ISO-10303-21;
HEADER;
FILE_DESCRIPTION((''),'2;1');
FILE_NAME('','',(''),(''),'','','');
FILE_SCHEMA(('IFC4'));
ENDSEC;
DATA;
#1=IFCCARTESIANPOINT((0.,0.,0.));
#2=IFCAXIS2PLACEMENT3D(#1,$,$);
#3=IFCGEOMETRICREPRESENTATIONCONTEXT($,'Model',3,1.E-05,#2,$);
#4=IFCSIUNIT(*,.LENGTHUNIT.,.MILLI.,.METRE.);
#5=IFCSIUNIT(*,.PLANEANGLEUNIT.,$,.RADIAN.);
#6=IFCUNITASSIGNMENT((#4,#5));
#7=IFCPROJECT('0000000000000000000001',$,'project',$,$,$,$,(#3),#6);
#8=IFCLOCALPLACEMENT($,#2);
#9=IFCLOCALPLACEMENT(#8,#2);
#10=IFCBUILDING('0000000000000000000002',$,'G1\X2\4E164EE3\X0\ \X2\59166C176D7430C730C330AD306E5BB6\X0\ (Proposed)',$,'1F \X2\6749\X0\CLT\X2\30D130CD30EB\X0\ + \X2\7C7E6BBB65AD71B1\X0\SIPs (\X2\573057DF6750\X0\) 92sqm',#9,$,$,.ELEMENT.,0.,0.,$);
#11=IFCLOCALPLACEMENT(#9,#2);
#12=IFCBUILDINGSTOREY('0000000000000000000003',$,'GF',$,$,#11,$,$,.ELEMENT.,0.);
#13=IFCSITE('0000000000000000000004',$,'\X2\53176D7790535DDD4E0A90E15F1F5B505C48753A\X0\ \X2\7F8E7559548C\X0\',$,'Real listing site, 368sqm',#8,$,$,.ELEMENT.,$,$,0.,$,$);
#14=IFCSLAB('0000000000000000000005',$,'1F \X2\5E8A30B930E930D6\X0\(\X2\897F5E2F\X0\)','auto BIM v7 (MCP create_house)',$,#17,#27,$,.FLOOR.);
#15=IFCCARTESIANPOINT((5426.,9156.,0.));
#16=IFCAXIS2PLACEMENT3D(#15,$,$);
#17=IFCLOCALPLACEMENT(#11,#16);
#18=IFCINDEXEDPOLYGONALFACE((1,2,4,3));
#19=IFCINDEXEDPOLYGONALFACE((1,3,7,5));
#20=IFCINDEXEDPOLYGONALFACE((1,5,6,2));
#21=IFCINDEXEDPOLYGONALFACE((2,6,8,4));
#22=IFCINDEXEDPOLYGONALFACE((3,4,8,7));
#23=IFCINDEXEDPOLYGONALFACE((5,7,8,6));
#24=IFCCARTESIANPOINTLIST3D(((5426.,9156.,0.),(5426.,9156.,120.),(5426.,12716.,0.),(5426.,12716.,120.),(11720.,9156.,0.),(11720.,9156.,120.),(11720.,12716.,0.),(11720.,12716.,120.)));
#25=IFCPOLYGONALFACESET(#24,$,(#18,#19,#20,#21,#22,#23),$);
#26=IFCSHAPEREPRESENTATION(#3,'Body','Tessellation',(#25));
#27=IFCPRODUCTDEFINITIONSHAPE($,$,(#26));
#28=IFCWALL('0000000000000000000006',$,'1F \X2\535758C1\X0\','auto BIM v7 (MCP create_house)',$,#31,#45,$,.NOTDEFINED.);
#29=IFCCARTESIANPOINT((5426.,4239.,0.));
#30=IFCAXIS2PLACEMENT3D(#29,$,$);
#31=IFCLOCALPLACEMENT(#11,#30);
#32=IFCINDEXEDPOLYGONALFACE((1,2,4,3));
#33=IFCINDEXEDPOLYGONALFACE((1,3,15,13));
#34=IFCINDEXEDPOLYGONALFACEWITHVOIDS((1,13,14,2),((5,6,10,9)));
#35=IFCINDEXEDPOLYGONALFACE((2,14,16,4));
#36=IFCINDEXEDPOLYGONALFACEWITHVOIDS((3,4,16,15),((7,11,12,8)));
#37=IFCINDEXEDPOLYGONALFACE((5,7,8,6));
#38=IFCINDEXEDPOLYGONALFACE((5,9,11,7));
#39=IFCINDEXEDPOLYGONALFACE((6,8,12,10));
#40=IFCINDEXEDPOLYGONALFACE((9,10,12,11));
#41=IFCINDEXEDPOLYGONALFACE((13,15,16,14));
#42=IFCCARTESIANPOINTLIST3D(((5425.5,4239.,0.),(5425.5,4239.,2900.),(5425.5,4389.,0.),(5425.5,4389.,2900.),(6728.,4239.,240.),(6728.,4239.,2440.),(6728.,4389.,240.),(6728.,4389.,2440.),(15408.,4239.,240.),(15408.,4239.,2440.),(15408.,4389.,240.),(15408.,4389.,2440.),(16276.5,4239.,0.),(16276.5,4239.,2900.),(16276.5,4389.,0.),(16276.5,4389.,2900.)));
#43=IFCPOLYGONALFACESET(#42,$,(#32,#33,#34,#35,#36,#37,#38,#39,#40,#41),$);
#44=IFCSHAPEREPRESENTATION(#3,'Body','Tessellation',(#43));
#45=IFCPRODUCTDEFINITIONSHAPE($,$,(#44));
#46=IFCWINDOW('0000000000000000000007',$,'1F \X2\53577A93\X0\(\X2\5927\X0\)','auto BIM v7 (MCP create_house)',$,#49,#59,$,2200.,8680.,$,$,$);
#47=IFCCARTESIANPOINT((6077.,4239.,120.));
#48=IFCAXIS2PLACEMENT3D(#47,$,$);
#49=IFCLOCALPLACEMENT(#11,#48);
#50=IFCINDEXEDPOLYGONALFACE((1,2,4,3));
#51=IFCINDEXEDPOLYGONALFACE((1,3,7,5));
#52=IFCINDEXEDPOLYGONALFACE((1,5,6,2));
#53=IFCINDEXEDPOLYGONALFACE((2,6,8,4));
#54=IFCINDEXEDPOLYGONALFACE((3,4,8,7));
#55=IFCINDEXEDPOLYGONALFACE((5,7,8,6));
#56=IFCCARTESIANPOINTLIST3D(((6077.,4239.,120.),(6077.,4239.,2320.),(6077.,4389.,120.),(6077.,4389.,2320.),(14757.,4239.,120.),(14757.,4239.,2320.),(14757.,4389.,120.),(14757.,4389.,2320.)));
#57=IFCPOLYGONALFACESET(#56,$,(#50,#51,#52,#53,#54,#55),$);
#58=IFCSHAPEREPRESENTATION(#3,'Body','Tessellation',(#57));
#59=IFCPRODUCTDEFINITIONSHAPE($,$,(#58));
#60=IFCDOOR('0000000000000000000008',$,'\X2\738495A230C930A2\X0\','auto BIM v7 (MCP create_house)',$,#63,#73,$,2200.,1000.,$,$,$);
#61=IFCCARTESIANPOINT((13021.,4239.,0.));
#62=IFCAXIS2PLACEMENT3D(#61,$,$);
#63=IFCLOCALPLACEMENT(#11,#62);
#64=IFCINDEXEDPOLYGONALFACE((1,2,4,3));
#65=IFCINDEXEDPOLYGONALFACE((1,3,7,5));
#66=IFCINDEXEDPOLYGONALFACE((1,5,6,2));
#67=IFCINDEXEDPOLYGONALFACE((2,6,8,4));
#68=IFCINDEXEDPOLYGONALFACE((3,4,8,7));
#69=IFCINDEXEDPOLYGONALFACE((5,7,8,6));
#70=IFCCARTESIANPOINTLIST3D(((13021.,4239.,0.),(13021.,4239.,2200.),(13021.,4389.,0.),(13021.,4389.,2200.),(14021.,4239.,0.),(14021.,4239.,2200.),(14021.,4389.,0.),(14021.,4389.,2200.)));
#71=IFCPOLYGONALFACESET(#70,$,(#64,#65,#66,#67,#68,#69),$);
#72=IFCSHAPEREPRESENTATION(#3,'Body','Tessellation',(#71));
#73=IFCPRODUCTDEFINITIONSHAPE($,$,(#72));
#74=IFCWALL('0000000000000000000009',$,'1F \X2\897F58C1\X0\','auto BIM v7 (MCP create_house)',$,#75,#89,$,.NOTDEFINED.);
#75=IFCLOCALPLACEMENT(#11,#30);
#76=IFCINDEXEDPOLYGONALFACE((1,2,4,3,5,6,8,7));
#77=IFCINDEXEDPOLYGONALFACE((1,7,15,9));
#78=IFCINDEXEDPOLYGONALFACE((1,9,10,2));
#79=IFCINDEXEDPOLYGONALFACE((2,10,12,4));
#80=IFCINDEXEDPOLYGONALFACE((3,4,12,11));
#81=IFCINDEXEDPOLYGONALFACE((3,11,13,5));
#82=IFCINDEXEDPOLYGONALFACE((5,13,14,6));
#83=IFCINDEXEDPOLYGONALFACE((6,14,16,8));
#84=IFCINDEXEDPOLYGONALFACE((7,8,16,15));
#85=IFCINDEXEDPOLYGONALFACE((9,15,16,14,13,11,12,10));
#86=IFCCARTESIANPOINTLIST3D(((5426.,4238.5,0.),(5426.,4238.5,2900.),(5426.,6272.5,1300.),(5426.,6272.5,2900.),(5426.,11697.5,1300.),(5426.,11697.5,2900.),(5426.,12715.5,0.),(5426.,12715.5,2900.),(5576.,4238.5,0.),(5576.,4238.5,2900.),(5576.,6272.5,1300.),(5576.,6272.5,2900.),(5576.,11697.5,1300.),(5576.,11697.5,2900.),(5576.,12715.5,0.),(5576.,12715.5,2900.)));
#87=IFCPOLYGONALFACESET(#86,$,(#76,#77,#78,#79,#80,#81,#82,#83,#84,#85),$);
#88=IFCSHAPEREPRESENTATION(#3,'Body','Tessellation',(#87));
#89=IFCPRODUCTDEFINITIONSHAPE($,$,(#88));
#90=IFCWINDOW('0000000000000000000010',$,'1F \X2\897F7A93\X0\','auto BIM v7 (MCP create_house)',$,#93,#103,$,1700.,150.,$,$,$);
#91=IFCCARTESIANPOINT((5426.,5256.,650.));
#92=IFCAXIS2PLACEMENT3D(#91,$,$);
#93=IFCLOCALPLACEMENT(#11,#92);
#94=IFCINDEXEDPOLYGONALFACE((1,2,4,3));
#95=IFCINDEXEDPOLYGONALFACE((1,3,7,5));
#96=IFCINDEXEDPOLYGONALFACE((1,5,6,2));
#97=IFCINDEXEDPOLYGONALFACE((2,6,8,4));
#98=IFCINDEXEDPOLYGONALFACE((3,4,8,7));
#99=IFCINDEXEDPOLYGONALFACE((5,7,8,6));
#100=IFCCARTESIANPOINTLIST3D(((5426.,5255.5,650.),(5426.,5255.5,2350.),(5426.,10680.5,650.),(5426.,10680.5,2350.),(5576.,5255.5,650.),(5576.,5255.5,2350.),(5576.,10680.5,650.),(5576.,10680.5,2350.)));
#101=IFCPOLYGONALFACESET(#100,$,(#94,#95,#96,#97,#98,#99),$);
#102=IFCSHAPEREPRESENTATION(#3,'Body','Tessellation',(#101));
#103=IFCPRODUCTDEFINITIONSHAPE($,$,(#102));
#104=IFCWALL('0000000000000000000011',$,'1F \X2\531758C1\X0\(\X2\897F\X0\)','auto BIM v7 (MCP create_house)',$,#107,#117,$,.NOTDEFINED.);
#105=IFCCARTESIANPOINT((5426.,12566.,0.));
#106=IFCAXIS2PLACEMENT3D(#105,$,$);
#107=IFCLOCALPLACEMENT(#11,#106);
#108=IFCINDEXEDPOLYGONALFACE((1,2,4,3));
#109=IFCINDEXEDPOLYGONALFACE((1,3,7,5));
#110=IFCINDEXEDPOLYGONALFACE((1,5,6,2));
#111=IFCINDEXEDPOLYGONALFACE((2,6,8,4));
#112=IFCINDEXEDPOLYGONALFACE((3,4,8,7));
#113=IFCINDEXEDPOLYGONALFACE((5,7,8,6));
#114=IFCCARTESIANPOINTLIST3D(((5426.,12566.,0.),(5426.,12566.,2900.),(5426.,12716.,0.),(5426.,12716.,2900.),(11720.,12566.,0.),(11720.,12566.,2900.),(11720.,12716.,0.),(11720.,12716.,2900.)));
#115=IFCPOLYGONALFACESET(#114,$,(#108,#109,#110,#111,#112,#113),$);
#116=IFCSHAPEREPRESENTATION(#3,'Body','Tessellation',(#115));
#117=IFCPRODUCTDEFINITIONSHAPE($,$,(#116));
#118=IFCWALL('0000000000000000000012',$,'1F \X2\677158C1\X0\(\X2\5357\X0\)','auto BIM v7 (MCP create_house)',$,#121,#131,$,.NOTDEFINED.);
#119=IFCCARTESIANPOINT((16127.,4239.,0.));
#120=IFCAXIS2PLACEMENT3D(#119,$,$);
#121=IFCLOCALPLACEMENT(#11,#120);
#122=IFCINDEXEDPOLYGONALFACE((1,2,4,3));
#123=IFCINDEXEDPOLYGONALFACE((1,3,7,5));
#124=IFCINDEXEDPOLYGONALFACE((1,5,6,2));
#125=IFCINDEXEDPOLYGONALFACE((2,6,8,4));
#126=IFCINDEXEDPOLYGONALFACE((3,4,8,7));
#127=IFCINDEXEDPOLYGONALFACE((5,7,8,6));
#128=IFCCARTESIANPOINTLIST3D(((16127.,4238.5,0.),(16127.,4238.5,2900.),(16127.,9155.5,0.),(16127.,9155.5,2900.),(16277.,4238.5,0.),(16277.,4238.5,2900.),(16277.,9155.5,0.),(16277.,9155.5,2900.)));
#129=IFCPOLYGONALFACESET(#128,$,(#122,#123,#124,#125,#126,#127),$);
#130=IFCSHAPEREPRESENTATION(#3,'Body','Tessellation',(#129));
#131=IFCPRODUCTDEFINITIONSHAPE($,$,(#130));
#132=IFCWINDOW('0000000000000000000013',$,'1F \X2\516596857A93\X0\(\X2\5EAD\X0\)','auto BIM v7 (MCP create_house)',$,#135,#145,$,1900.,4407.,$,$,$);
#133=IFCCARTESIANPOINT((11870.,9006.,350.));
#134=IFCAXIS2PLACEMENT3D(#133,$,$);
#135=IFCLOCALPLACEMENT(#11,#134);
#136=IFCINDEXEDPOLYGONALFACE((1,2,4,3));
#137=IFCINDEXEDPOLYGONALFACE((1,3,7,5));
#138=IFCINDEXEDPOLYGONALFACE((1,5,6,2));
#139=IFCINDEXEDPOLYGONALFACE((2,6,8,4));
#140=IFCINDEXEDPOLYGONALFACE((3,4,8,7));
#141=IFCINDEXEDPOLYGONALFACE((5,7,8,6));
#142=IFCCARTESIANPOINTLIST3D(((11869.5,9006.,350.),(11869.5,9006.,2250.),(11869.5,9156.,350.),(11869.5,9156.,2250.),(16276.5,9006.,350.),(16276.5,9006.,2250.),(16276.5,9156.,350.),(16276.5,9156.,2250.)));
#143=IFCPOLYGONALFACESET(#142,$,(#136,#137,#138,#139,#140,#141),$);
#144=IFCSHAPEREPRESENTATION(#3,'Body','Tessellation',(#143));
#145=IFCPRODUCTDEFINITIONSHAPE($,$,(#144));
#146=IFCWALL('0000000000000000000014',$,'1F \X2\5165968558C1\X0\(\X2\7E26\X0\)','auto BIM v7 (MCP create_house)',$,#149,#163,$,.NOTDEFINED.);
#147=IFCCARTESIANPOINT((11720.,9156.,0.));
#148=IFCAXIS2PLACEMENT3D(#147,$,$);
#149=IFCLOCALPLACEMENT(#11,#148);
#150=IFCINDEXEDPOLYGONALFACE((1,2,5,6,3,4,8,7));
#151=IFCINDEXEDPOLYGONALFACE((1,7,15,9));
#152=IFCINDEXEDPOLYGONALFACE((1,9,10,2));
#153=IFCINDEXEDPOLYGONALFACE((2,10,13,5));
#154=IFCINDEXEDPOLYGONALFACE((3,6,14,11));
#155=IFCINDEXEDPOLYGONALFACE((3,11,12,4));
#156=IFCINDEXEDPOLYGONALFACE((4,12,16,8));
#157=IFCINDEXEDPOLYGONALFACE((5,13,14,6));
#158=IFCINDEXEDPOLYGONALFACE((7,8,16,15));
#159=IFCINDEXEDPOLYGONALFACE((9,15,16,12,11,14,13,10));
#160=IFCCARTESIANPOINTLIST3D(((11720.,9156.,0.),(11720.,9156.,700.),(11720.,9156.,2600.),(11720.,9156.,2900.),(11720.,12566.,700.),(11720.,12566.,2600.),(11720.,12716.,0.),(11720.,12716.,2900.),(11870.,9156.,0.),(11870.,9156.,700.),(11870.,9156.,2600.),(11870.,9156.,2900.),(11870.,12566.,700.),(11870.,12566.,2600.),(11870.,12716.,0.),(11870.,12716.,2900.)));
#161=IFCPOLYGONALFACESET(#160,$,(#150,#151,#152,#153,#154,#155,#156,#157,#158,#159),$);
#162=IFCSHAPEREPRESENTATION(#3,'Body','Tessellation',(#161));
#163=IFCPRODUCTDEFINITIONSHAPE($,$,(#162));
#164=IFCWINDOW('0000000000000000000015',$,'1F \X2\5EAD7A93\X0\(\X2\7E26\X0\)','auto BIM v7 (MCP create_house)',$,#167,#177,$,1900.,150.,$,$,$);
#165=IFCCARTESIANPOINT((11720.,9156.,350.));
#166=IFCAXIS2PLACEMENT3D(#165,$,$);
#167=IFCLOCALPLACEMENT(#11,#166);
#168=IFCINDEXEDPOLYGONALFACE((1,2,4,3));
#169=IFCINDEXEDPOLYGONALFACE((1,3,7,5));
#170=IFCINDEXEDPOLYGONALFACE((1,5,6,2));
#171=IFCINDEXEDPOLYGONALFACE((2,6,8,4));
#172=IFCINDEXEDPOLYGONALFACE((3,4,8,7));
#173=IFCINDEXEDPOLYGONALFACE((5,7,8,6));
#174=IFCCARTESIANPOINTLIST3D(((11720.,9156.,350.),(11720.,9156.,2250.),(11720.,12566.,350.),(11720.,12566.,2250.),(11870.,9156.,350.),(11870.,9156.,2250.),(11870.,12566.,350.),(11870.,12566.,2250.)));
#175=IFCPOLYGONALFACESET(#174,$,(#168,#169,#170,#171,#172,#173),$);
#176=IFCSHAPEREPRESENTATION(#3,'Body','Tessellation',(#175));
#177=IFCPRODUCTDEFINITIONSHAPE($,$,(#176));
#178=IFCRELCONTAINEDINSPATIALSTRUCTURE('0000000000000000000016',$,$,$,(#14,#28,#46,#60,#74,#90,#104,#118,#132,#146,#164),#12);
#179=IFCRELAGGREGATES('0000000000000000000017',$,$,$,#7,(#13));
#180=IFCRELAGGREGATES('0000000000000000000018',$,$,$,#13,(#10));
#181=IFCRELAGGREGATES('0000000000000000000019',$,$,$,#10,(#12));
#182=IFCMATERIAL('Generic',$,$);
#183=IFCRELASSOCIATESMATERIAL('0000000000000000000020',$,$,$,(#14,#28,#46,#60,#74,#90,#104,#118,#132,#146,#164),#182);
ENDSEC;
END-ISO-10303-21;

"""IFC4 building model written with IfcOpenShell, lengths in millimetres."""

from ifc_helpers import new_model, si_unit, frame, frame_2d, origin, place, context, project, spatial, rectangle, extrude, material, element, fill, save


model = new_model("IFC4")

# Units and contexts
model_context = context("Model", 3, precision=1e-05, world=origin())
ifc_project = project(units=[si_unit("LENGTHUNIT", "METRE", prefix="MILLI"), si_unit("PLANEANGLEUNIT", "RADIAN")], contexts=[model_context])

# Site, building, storey
site_placement = place(None, origin())
site = spatial("IfcSite", under=ifc_project, at=site_placement, Name="北海道川上郡弟子屈町 美留和", ObjectType="Real listing site, 368sqm", CompositionType="ELEMENT", RefElevation=0.0)
building_placement = place(site_placement, origin())
building = spatial("IfcBuilding", under=site, at=building_placement, Name="G1世代 外気浴デッキの家 (Proposed)", ObjectType="1F 杉CLTパネル + 籾殻断熱SIPs (地域材) 92sqm", CompositionType="ELEMENT", ElevationOfRefHeight=0.0, ElevationOfTerrain=0.0)
storey_placement = place(building_placement, origin())
storey = spatial("IfcBuildingStorey", under=building, at=storey_placement, Name="GF", CompositionType="ELEMENT", Elevation=0.0)

# Slab
ifc_material = material(Name="Generic")
slab_1_placement = place(storey_placement, frame((5426.0, 9156.0, 0.0)))
element("IfcSlab", 1, at=slab_1_placement, inside=storey, material=ifc_material, Name="1F 床スラブ(西帯)", Description="auto BIM v7 (MCP create_house)", PredefinedType="FLOOR", context=model_context, shape_type="SweptSolid", body=[
    extrude(rectangle(XDim=6294.0, YDim=3560.0, at=frame_2d((3147.0, 1780.0))), frame((5426.0, 9156.0, 0.0)), (0.0, 0.0, 1.0), 120.0),
])

# Wall, openings, window, door
wall_1_placement = place(storey_placement, frame((5426.0, 4239.0, 0.0)))
wall_1 = element("IfcWall", 2, at=wall_1_placement, inside=storey, material=ifc_material, Name="1F 南壁", Description="auto BIM v7 (MCP create_house)", PredefinedType="NOTDEFINED", context=model_context, shape_type="SweptSolid", body=[
    extrude(rectangle(XDim=10851.0, YDim=150.0, at=frame_2d((5425.0, 75.0))), frame((5426.0, 4239.0, 0.0)), (0.0, 0.0, 1.0), 2900.0),
])
opening_1_placement = place(storey_placement, frame((6077.0, 4239.0, 120.0)))
opening_1 = element("IfcOpeningElement", 3, at=opening_1_placement, cuts=wall_1, PredefinedType="NOTDEFINED", context=model_context, shape_type="SweptSolid", body=[
    extrude(rectangle(XDim=8680.0, YDim=150.0, at=frame_2d((4340.0, 75.0))), frame((6077.0, 4239.0, 120.0)), (0.0, 0.0, 1.0), 2200.0),
])
opening_2_placement = place(storey_placement, frame((13021.0, 4239.0, 0.0)))
opening_2 = element("IfcOpeningElement", 4, at=opening_2_placement, cuts=wall_1, PredefinedType="NOTDEFINED", context=model_context, shape_type="SweptSolid", body=[
    extrude(rectangle(XDim=1000.0, YDim=150.0, at=frame_2d((500.0, 75.0))), frame((13021.0, 4239.0, 0.0)), (0.0, 0.0, 1.0), 2200.0),
])
window_1_placement = place(storey_placement, frame((6077.0, 4239.0, 120.0)))
window_1 = element("IfcWindow", 5, at=window_1_placement, inside=storey, material=ifc_material, Name="1F 南窓(大)", Description="auto BIM v7 (MCP create_house)", OverallHeight=2200.0, OverallWidth=8680.0, context=model_context, shape_type="SweptSolid", body=[
    extrude(rectangle(XDim=8680.0, YDim=150.0, at=frame_2d((4340.0, 75.0))), frame((6077.0, 4239.0, 120.0)), (0.0, 0.0, 1.0), 2200.0),
])
fill(opening_1, window_1)
door_placement = place(storey_placement, frame((13021.0, 4239.0, 0.0)))
door = element("IfcDoor", 6, at=door_placement, inside=storey, material=ifc_material, Name="玄関ドア", Description="auto BIM v7 (MCP create_house)", OverallHeight=2200.0, OverallWidth=1000.0, context=model_context, shape_type="SweptSolid", body=[
    extrude(rectangle(XDim=1000.0, YDim=150.0, at=frame_2d((500.0, 75.0))), frame((13021.0, 4239.0, 0.0)), (0.0, 0.0, 1.0), 2200.0),
])
fill(opening_2, door)

# Wall, opening, window
wall_2_placement = place(storey_placement, frame((5426.0, 4239.0, 0.0)))
wall_2 = element("IfcWall", 7, at=wall_2_placement, inside=storey, material=ifc_material, Name="1F 西壁", Description="auto BIM v7 (MCP create_house)", PredefinedType="NOTDEFINED", context=model_context, shape_type="SweptSolid", body=[
    extrude(rectangle(XDim=150.0, YDim=8477.0, at=frame_2d((75.0, 4238.0))), frame((5426.0, 4239.0, 0.0)), (0.0, 0.0, 1.0), 2900.0),
])
opening_3_placement = place(storey_placement, frame((5426.0, 5256.0, 650.0)))
opening_3 = element("IfcOpeningElement", 8, at=opening_3_placement, cuts=wall_2, PredefinedType="NOTDEFINED", context=model_context, shape_type="SweptSolid", body=[
    extrude(rectangle(XDim=150.0, YDim=5425.0, at=frame_2d((75.0, 2712.0))), frame((5426.0, 5256.0, 650.0)), (0.0, 0.0, 1.0), 1700.0),
])
window_2_placement = place(storey_placement, frame((5426.0, 5256.0, 650.0)))
window_2 = element("IfcWindow", 9, at=window_2_placement, inside=storey, material=ifc_material, Name="1F 西窓", Description="auto BIM v7 (MCP create_house)", OverallHeight=1700.0, OverallWidth=150.0, context=model_context, shape_type="SweptSolid", body=[
    extrude(rectangle(XDim=150.0, YDim=5425.0, at=frame_2d((75.0, 2712.0))), frame((5426.0, 5256.0, 650.0)), (0.0, 0.0, 1.0), 1700.0),
])
fill(opening_3, window_2)

# Wall
wall_3_placement = place(storey_placement, frame((5426.0, 12566.0, 0.0)))
element("IfcWall", 10, at=wall_3_placement, inside=storey, material=ifc_material, Name="1F 北壁(西)", Description="auto BIM v7 (MCP create_house)", PredefinedType="NOTDEFINED", context=model_context, shape_type="SweptSolid", body=[
    extrude(rectangle(XDim=6294.0, YDim=150.0, at=frame_2d((3147.0, 75.0))), frame((5426.0, 12566.0, 0.0)), (0.0, 0.0, 1.0), 2900.0),
])

# Wall, opening, window
wall_4_placement = place(storey_placement, frame((16127.0, 4239.0, 0.0)))
wall_4 = element("IfcWall", 11, at=wall_4_placement, inside=storey, material=ifc_material, Name="1F 東壁(南)", Description="auto BIM v7 (MCP create_house)", PredefinedType="NOTDEFINED", context=model_context, shape_type="SweptSolid", body=[
    extrude(rectangle(XDim=150.0, YDim=4917.0, at=frame_2d((75.0, 2458.0))), frame((16127.0, 4239.0, 0.0)), (0.0, 0.0, 1.0), 2900.0),
])
opening_4_placement = place(storey_placement, frame((11870.0, 9006.0, 350.0)))
opening_4 = element("IfcOpeningElement", 12, at=opening_4_placement, cuts=wall_4, PredefinedType="NOTDEFINED", context=model_context, shape_type="SweptSolid", body=[
    extrude(rectangle(XDim=4407.0, YDim=150.0, at=frame_2d((2203.0, 75.0))), frame((11870.0, 9006.0, 350.0)), (0.0, 0.0, 1.0), 1900.0),
])
window_3_placement = place(storey_placement, frame((11870.0, 9006.0, 350.0)))
window_3 = element("IfcWindow", 13, at=window_3_placement, inside=storey, material=ifc_material, Name="1F 入隅窓(庭)", Description="auto BIM v7 (MCP create_house)", OverallHeight=1900.0, OverallWidth=4407.0, context=model_context, shape_type="SweptSolid", body=[
    extrude(rectangle(XDim=4407.0, YDim=150.0, at=frame_2d((2203.0, 75.0))), frame((11870.0, 9006.0, 350.0)), (0.0, 0.0, 1.0), 1900.0),
])
fill(opening_4, window_3)

# Wall, opening, window
wall_5_placement = place(storey_placement, frame((11720.0, 9156.0, 0.0)))
wall_5 = element("IfcWall", 14, at=wall_5_placement, inside=storey, material=ifc_material, Name="1F 入隅壁(縦)", Description="auto BIM v7 (MCP create_house)", PredefinedType="NOTDEFINED", context=model_context, shape_type="SweptSolid", body=[
    extrude(rectangle(XDim=150.0, YDim=3560.0, at=frame_2d((75.0, 1780.0))), frame((11720.0, 9156.0, 0.0)), (0.0, 0.0, 1.0), 2900.0),
])
opening_5_placement = place(storey_placement, frame((11720.0, 9156.0, 350.0)))
opening_5 = element("IfcOpeningElement", 15, at=opening_5_placement, cuts=wall_5, PredefinedType="NOTDEFINED", context=model_context, shape_type="SweptSolid", body=[
    extrude(rectangle(XDim=150.0, YDim=3410.0, at=frame_2d((75.0, 1705.0))), frame((11720.0, 9156.0, 350.0)), (0.0, 0.0, 1.0), 1900.0),
])
window_4_placement = place(storey_placement, frame((11720.0, 9156.0, 350.0)))
window_4 = element("IfcWindow", 16, at=window_4_placement, inside=storey, material=ifc_material, Name="1F 庭窓(縦)", Description="auto BIM v7 (MCP create_house)", OverallHeight=1900.0, OverallWidth=150.0, context=model_context, shape_type="SweptSolid", body=[
    extrude(rectangle(XDim=150.0, YDim=3410.0, at=frame_2d((75.0, 1705.0))), frame((11720.0, 9156.0, 350.0)), (0.0, 0.0, 1.0), 1900.0),
])
fill(opening_5, window_4)

save(model, "model.ifc")
